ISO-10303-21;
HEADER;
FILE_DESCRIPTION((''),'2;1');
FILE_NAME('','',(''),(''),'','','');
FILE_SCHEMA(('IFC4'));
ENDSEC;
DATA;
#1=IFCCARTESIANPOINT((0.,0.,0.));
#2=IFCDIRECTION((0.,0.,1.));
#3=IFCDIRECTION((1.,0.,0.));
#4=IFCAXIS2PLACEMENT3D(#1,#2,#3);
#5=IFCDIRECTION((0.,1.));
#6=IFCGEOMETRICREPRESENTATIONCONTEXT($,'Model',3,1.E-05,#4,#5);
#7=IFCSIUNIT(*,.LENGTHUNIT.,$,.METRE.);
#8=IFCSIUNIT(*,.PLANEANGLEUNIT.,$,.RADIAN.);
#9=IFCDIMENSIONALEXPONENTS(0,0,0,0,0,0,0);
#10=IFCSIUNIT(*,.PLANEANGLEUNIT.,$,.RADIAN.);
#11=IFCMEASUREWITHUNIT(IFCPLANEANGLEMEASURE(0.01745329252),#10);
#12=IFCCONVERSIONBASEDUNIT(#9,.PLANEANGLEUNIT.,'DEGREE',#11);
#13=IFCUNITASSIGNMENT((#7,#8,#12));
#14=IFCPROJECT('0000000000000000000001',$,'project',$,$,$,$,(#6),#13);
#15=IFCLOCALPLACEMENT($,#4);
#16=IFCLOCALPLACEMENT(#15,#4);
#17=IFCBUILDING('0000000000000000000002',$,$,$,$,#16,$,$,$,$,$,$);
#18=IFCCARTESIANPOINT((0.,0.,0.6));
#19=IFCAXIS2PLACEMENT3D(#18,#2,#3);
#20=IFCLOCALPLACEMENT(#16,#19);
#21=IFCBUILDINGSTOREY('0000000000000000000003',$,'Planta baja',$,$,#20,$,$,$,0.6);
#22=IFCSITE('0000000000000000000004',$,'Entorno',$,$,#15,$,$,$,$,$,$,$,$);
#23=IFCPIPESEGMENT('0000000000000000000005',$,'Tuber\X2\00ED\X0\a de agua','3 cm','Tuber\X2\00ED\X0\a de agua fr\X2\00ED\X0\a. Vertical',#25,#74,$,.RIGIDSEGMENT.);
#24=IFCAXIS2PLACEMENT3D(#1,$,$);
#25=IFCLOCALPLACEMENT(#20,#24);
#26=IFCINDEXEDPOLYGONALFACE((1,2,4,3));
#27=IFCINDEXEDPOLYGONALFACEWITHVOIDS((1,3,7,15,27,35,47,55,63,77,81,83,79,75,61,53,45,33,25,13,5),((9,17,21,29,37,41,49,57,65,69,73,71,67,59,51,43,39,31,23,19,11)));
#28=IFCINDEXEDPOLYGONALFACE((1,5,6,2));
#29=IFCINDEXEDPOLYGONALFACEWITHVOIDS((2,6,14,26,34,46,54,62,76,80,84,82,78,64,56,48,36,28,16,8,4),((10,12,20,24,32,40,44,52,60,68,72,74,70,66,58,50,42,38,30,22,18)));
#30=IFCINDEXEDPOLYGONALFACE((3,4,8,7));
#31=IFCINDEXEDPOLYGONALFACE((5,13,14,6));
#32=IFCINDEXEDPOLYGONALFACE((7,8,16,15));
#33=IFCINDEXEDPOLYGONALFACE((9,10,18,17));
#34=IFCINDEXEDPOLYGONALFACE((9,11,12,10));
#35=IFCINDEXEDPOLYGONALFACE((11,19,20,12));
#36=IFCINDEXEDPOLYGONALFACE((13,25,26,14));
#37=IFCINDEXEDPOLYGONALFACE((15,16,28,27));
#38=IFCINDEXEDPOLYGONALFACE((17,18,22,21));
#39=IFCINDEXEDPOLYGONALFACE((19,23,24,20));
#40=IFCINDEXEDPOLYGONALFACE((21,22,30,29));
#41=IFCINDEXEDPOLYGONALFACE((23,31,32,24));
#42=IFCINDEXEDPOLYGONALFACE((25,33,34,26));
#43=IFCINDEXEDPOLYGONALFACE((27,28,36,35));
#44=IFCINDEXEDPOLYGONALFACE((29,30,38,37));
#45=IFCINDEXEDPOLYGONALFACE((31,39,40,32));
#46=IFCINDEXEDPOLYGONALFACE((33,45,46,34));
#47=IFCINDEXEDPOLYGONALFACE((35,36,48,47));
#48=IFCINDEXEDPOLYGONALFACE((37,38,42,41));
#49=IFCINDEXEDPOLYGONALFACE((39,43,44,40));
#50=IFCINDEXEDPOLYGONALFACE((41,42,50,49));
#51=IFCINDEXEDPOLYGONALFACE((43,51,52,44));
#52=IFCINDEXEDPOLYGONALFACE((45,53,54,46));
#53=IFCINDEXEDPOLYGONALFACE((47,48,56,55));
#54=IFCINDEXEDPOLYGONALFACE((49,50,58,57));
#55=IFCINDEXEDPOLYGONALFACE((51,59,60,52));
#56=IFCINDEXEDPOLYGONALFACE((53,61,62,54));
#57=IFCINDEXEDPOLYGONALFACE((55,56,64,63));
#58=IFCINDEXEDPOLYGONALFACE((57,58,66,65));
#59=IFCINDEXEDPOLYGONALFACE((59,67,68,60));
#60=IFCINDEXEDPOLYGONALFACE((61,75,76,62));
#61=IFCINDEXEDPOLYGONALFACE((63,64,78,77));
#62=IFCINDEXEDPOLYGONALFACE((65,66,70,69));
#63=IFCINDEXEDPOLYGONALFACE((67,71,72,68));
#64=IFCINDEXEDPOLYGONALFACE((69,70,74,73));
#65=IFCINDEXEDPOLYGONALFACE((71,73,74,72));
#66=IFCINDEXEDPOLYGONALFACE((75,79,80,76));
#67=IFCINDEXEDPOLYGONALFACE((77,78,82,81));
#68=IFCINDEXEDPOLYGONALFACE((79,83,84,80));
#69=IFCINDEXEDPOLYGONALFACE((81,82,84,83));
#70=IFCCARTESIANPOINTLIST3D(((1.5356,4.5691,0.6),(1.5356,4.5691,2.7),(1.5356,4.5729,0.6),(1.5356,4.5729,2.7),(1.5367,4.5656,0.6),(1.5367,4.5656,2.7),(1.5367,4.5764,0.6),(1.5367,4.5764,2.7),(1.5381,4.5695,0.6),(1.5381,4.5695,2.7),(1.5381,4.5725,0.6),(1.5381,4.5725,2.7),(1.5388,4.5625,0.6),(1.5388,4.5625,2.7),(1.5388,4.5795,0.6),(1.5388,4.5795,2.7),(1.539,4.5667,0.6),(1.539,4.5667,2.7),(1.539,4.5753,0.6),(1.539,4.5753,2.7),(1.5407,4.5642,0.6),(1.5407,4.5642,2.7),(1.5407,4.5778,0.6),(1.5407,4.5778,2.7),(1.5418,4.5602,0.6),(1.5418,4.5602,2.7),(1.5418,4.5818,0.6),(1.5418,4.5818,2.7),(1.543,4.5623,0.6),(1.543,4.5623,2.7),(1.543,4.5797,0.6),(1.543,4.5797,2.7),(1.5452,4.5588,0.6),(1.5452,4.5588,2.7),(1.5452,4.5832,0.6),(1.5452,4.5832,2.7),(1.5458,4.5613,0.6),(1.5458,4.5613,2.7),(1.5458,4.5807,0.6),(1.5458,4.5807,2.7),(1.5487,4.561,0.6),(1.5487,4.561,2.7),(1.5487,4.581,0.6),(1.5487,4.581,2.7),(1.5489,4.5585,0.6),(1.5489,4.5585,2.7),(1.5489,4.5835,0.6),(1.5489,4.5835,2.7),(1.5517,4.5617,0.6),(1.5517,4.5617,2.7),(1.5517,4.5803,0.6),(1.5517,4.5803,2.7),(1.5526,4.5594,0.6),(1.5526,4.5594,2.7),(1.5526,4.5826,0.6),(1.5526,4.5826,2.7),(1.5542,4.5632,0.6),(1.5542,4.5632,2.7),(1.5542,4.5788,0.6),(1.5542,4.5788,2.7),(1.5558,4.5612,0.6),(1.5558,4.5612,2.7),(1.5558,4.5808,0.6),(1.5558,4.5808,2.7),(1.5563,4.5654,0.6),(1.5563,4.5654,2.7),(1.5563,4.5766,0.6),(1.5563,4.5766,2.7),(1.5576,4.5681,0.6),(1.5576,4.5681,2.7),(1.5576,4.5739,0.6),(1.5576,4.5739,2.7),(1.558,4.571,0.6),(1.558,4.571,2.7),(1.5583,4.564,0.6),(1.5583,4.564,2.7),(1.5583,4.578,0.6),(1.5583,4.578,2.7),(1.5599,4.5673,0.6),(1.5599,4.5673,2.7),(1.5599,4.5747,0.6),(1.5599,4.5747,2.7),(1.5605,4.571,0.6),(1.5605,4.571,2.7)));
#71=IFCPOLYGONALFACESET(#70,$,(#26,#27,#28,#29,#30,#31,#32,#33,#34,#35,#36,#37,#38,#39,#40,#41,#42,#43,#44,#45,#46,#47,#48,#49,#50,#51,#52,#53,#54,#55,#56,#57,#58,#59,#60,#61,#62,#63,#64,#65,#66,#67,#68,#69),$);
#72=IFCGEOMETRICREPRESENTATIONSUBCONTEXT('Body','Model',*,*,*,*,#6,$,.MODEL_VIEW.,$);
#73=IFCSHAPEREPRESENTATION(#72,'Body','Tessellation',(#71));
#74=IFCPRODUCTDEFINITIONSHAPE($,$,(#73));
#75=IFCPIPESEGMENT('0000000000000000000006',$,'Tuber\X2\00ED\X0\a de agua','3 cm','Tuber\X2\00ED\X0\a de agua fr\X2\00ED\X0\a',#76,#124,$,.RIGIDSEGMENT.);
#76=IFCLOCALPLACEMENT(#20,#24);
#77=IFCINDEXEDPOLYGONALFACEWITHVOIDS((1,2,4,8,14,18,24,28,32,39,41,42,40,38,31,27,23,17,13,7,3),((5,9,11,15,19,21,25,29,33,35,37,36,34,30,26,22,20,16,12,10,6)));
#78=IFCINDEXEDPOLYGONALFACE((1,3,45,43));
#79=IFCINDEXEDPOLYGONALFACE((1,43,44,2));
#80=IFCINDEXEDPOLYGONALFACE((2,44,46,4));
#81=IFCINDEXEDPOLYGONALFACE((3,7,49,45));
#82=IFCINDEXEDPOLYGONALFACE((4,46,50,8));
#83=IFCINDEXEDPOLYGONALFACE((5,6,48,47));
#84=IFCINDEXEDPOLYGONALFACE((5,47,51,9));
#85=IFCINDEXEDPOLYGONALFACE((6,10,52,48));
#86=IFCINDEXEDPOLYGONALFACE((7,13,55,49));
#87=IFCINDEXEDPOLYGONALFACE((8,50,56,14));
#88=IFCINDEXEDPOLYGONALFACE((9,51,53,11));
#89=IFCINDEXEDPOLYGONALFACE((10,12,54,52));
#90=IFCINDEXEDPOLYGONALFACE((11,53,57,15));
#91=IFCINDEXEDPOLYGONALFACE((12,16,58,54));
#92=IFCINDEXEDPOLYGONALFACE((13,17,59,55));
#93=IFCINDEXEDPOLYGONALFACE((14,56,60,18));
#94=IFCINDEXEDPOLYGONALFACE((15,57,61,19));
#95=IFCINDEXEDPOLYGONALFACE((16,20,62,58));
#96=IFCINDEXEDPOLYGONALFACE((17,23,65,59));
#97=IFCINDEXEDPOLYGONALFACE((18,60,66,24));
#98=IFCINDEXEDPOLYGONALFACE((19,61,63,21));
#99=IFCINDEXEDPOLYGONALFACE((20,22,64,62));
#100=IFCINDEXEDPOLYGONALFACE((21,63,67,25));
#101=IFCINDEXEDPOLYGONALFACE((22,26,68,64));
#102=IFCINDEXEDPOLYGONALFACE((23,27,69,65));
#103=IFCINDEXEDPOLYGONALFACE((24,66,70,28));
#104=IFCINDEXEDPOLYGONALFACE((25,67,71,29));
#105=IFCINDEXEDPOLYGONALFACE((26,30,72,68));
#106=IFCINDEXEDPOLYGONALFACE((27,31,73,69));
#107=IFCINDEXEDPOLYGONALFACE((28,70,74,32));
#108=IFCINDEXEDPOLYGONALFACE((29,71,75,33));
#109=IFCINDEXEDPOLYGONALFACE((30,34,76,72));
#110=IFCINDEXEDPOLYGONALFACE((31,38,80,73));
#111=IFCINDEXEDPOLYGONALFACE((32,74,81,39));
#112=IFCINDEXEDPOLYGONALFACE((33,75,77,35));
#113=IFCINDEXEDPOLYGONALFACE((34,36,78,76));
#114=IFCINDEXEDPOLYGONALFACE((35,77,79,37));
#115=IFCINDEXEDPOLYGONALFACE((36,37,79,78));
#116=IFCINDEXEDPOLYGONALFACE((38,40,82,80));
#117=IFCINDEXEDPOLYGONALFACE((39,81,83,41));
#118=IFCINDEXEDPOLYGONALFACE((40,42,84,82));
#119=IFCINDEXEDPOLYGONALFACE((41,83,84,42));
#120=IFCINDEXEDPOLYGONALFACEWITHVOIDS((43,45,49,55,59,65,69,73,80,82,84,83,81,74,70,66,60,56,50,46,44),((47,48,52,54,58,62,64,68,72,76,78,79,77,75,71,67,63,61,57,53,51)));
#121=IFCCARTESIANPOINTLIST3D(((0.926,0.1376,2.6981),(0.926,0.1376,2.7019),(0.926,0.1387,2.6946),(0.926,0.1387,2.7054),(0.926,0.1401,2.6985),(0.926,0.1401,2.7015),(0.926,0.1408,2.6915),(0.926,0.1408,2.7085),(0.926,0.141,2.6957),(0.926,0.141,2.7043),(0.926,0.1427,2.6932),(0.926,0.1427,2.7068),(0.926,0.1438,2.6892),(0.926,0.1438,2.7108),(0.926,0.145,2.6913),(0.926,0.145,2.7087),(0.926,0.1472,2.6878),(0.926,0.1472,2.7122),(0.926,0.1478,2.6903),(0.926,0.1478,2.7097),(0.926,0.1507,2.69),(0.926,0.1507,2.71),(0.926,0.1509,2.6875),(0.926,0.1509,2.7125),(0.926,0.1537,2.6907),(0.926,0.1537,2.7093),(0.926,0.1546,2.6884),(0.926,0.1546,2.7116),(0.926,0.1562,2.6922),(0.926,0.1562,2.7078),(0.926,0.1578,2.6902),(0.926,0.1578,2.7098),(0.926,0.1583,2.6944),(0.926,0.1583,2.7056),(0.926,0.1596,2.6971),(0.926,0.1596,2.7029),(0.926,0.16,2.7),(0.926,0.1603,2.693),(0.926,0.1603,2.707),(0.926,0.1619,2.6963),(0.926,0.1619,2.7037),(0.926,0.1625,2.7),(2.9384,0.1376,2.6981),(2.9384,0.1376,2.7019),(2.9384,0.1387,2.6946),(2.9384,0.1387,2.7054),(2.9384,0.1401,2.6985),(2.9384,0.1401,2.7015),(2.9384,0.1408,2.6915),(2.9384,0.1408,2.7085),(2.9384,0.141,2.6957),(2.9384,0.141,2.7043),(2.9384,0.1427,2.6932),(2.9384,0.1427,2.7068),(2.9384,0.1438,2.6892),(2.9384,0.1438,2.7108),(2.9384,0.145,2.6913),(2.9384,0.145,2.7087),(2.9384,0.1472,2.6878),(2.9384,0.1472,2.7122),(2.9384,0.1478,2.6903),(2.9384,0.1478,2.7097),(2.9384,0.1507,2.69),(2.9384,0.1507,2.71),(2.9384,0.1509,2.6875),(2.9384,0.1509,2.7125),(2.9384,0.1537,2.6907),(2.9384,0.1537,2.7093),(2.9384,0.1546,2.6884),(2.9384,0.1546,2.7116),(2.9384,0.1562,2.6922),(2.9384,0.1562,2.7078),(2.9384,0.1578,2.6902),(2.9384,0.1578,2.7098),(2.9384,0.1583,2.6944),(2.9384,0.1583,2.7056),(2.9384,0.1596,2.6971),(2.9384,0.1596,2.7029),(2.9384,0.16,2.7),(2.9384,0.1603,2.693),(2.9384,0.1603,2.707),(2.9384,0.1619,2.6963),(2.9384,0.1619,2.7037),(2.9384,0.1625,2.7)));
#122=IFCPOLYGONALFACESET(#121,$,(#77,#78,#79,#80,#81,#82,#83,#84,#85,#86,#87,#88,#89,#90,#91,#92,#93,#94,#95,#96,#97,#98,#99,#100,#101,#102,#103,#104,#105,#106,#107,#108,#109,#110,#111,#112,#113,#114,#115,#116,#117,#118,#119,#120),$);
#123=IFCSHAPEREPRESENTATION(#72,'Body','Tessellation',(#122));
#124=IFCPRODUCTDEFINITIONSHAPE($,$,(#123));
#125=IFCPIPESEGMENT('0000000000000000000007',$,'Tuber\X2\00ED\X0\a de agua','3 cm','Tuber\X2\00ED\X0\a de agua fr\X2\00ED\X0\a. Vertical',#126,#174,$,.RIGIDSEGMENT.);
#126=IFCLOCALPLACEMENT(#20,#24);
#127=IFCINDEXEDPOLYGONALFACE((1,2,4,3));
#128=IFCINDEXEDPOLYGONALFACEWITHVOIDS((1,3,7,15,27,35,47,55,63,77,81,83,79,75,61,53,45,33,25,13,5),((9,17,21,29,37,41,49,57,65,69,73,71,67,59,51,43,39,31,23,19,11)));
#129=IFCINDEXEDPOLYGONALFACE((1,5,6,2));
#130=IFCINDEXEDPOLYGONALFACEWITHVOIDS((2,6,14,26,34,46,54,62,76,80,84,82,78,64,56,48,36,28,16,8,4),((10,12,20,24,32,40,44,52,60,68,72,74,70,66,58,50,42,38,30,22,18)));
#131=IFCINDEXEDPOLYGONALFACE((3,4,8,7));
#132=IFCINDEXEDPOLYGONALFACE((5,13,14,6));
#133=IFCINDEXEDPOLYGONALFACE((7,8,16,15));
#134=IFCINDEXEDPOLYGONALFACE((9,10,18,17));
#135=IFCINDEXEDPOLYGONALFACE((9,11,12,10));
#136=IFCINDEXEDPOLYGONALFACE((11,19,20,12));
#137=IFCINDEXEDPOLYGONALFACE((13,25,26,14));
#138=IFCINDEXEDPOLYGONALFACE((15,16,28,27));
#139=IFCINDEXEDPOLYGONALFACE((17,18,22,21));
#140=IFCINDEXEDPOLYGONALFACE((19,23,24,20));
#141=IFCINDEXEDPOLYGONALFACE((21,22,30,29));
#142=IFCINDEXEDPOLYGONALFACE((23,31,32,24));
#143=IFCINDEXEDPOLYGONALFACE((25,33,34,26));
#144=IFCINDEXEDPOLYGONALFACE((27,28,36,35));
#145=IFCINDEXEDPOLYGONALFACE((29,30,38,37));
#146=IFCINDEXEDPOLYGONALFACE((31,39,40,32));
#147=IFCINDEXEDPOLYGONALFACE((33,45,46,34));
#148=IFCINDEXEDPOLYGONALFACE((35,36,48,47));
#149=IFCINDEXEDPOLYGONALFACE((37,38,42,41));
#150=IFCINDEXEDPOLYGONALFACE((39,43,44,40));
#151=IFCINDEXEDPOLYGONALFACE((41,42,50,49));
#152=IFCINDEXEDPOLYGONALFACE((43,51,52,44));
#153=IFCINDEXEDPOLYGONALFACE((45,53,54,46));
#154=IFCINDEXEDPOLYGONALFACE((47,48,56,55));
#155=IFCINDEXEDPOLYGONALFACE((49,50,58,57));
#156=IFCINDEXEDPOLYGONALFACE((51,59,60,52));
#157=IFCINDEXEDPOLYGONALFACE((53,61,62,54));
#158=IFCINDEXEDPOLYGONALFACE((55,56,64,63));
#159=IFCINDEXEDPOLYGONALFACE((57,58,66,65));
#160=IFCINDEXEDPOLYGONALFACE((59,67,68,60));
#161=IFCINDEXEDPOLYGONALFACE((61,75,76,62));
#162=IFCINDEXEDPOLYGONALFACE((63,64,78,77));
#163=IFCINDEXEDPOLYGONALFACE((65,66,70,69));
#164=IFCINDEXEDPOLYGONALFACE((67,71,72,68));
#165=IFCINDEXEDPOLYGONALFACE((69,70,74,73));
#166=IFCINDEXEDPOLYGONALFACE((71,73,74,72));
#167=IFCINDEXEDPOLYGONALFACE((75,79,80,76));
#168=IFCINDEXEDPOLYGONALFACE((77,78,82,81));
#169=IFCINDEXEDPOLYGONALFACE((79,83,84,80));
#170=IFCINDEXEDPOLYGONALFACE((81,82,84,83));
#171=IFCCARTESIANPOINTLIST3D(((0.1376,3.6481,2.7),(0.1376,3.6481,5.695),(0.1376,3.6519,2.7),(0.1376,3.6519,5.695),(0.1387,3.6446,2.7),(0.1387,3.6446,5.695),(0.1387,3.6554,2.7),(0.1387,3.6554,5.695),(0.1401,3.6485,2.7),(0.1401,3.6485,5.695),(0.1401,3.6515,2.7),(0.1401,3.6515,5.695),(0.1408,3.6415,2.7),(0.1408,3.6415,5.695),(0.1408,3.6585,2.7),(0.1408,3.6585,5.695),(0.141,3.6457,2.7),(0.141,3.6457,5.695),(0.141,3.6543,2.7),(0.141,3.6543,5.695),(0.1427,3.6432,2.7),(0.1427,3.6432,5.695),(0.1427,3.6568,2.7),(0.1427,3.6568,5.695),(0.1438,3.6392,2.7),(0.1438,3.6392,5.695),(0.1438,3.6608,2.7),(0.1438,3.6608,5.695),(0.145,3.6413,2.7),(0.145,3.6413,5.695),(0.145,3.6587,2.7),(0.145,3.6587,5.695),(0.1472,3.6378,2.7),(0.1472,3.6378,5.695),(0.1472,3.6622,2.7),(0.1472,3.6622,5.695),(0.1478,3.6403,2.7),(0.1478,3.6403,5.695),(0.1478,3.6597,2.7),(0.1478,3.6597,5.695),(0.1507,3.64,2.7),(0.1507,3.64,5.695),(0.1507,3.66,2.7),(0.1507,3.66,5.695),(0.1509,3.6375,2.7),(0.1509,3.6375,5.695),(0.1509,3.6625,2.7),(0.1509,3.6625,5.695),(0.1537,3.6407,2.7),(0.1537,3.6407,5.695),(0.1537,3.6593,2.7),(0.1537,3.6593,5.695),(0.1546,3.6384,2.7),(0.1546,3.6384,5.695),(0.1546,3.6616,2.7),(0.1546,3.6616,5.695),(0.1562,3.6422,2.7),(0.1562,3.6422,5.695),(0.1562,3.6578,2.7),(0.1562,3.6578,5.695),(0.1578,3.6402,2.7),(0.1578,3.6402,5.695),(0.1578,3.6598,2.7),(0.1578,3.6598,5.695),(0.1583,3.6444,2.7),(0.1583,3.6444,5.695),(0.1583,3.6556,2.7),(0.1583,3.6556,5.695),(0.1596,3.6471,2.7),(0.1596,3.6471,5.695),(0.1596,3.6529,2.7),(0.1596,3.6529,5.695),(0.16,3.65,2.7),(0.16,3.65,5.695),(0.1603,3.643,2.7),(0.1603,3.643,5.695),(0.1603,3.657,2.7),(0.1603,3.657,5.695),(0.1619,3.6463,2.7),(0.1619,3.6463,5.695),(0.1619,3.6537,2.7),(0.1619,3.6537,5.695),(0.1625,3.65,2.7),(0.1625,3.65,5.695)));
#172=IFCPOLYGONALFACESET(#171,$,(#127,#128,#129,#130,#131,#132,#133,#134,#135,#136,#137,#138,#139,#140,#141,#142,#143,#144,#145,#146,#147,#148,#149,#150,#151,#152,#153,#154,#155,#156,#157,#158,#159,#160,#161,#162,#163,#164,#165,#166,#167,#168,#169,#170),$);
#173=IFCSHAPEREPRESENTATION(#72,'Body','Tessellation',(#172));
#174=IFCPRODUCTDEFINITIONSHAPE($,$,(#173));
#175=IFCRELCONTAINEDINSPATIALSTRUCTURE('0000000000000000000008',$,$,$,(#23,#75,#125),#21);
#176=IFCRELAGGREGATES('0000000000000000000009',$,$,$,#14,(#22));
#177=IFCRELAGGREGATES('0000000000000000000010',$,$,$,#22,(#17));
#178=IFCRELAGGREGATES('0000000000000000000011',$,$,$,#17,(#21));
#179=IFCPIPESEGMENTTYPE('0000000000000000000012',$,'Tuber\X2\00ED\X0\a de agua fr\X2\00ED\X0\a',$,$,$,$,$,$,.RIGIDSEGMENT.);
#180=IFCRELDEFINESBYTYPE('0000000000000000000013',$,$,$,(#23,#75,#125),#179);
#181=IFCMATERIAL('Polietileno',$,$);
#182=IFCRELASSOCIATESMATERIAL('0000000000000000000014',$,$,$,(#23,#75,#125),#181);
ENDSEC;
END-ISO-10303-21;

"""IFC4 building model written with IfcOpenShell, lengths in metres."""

from ifc_helpers import new_model, entity, si_unit, converted_unit, direction, frame, origin_with_axes, origin_2d_with_axis, place, context, subcontext, project, spatial, hollow_circle, extrude, material, type_object, element, save


model = new_model("IFC4")

# Units and contexts
model_context = context("Model", 3, precision=1e-05, world=origin_with_axes(), true_north=direction((0.0, 1.0)))
body_context = subcontext(model_context, "Body", "Model", "MODEL_VIEW")
ifc_project = project(units=[si_unit("LENGTHUNIT", "METRE"), si_unit("PLANEANGLEUNIT", "RADIAN"), converted_unit("PLANEANGLEUNIT", "DEGREE", entity("IfcPlaneAngleMeasure", 0.01745329252), si_unit("PLANEANGLEUNIT", "RADIAN"), dimensions=[0, 0, 0, 0, 0, 0, 0])], contexts=[model_context])

# Site, building, storey
site_placement = place(None, origin_with_axes())
site = spatial("IfcSite", under=ifc_project, at=site_placement, Name="Entorno")
building_placement = place(site_placement, origin_with_axes())
building = spatial("IfcBuilding", under=site, at=building_placement)
storey_placement = place(building_placement, frame((0.0, 0.0, 0.6), z_axis=(0.0, 0.0, 1.0), x_axis=(1.0, 0.0, 0.0)))
storey = spatial("IfcBuildingStorey", under=building, at=storey_placement, Name="Planta baja", Elevation=0.6)

# Pipe segments
ifc_material_1 = material(Name="Polietileno")
pipe_segment_type_1 = type_object("IfcPipeSegmentType", Name="Tubería de agua fría", PredefinedType="RIGIDSEGMENT")
pipe_segment_1_placement = place(storey_placement, frame((1.548, 4.571, 2.7), z_axis=(0.0, 0.0, -1.0), x_axis=(1.0, 0.0, 0.0)))
element("IfcPipeSegment", 1, at=pipe_segment_1_placement, inside=storey, type_object=pipe_segment_type_1, material=ifc_material_1, Name="Tubería de agua", Description="3 cm", ObjectType="Tubería de agua fría. Vertical", PredefinedType="RIGIDSEGMENT", context=body_context, shape_type="SweptSolid", body=[
    extrude(hollow_circle(Radius=0.0125, WallThickness=0.0025, at=origin_2d_with_axis()), origin_with_axes(), (0.0, 0.0, 1.0), 2.1),
])
pipe_segment_2_placement = place(storey_placement, frame((0.926, 0.15, 2.7), z_axis=(1.0, 0.0, 0.0), x_axis=(0.0, 1.0, 0.0)))
element("IfcPipeSegment", 2, at=pipe_segment_2_placement, inside=storey, type_object=pipe_segment_type_1, material=ifc_material_1, Name="Tubería de agua", Description="3 cm", ObjectType="Tubería de agua fría", PredefinedType="RIGIDSEGMENT", context=body_context, shape_type="SweptSolid", body=[
    extrude(hollow_circle(Radius=0.0125, WallThickness=0.0025, at=origin_2d_with_axis()), origin_with_axes(), (0.0, 0.0, 1.0), 2.0125),
])
pipe_segment_3_placement = place(storey_placement, frame((0.15, 3.65, 2.7), z_axis=(0.0, 0.0, 1.0), x_axis=(1.0, 0.0, 0.0)))
element("IfcPipeSegment", 3, at=pipe_segment_3_placement, inside=storey, type_object=pipe_segment_type_1, material=ifc_material_1, Name="Tubería de agua", Description="3 cm", ObjectType="Tubería de agua fría. Vertical", PredefinedType="RIGIDSEGMENT", context=body_context, shape_type="SweptSolid", body=[
    extrude(hollow_circle(Radius=0.0125, WallThickness=0.0025, at=origin_2d_with_axis()), origin_with_axes(), (0.0, 0.0, 1.0), 2.995),
])

save(model, "model.ifc")
